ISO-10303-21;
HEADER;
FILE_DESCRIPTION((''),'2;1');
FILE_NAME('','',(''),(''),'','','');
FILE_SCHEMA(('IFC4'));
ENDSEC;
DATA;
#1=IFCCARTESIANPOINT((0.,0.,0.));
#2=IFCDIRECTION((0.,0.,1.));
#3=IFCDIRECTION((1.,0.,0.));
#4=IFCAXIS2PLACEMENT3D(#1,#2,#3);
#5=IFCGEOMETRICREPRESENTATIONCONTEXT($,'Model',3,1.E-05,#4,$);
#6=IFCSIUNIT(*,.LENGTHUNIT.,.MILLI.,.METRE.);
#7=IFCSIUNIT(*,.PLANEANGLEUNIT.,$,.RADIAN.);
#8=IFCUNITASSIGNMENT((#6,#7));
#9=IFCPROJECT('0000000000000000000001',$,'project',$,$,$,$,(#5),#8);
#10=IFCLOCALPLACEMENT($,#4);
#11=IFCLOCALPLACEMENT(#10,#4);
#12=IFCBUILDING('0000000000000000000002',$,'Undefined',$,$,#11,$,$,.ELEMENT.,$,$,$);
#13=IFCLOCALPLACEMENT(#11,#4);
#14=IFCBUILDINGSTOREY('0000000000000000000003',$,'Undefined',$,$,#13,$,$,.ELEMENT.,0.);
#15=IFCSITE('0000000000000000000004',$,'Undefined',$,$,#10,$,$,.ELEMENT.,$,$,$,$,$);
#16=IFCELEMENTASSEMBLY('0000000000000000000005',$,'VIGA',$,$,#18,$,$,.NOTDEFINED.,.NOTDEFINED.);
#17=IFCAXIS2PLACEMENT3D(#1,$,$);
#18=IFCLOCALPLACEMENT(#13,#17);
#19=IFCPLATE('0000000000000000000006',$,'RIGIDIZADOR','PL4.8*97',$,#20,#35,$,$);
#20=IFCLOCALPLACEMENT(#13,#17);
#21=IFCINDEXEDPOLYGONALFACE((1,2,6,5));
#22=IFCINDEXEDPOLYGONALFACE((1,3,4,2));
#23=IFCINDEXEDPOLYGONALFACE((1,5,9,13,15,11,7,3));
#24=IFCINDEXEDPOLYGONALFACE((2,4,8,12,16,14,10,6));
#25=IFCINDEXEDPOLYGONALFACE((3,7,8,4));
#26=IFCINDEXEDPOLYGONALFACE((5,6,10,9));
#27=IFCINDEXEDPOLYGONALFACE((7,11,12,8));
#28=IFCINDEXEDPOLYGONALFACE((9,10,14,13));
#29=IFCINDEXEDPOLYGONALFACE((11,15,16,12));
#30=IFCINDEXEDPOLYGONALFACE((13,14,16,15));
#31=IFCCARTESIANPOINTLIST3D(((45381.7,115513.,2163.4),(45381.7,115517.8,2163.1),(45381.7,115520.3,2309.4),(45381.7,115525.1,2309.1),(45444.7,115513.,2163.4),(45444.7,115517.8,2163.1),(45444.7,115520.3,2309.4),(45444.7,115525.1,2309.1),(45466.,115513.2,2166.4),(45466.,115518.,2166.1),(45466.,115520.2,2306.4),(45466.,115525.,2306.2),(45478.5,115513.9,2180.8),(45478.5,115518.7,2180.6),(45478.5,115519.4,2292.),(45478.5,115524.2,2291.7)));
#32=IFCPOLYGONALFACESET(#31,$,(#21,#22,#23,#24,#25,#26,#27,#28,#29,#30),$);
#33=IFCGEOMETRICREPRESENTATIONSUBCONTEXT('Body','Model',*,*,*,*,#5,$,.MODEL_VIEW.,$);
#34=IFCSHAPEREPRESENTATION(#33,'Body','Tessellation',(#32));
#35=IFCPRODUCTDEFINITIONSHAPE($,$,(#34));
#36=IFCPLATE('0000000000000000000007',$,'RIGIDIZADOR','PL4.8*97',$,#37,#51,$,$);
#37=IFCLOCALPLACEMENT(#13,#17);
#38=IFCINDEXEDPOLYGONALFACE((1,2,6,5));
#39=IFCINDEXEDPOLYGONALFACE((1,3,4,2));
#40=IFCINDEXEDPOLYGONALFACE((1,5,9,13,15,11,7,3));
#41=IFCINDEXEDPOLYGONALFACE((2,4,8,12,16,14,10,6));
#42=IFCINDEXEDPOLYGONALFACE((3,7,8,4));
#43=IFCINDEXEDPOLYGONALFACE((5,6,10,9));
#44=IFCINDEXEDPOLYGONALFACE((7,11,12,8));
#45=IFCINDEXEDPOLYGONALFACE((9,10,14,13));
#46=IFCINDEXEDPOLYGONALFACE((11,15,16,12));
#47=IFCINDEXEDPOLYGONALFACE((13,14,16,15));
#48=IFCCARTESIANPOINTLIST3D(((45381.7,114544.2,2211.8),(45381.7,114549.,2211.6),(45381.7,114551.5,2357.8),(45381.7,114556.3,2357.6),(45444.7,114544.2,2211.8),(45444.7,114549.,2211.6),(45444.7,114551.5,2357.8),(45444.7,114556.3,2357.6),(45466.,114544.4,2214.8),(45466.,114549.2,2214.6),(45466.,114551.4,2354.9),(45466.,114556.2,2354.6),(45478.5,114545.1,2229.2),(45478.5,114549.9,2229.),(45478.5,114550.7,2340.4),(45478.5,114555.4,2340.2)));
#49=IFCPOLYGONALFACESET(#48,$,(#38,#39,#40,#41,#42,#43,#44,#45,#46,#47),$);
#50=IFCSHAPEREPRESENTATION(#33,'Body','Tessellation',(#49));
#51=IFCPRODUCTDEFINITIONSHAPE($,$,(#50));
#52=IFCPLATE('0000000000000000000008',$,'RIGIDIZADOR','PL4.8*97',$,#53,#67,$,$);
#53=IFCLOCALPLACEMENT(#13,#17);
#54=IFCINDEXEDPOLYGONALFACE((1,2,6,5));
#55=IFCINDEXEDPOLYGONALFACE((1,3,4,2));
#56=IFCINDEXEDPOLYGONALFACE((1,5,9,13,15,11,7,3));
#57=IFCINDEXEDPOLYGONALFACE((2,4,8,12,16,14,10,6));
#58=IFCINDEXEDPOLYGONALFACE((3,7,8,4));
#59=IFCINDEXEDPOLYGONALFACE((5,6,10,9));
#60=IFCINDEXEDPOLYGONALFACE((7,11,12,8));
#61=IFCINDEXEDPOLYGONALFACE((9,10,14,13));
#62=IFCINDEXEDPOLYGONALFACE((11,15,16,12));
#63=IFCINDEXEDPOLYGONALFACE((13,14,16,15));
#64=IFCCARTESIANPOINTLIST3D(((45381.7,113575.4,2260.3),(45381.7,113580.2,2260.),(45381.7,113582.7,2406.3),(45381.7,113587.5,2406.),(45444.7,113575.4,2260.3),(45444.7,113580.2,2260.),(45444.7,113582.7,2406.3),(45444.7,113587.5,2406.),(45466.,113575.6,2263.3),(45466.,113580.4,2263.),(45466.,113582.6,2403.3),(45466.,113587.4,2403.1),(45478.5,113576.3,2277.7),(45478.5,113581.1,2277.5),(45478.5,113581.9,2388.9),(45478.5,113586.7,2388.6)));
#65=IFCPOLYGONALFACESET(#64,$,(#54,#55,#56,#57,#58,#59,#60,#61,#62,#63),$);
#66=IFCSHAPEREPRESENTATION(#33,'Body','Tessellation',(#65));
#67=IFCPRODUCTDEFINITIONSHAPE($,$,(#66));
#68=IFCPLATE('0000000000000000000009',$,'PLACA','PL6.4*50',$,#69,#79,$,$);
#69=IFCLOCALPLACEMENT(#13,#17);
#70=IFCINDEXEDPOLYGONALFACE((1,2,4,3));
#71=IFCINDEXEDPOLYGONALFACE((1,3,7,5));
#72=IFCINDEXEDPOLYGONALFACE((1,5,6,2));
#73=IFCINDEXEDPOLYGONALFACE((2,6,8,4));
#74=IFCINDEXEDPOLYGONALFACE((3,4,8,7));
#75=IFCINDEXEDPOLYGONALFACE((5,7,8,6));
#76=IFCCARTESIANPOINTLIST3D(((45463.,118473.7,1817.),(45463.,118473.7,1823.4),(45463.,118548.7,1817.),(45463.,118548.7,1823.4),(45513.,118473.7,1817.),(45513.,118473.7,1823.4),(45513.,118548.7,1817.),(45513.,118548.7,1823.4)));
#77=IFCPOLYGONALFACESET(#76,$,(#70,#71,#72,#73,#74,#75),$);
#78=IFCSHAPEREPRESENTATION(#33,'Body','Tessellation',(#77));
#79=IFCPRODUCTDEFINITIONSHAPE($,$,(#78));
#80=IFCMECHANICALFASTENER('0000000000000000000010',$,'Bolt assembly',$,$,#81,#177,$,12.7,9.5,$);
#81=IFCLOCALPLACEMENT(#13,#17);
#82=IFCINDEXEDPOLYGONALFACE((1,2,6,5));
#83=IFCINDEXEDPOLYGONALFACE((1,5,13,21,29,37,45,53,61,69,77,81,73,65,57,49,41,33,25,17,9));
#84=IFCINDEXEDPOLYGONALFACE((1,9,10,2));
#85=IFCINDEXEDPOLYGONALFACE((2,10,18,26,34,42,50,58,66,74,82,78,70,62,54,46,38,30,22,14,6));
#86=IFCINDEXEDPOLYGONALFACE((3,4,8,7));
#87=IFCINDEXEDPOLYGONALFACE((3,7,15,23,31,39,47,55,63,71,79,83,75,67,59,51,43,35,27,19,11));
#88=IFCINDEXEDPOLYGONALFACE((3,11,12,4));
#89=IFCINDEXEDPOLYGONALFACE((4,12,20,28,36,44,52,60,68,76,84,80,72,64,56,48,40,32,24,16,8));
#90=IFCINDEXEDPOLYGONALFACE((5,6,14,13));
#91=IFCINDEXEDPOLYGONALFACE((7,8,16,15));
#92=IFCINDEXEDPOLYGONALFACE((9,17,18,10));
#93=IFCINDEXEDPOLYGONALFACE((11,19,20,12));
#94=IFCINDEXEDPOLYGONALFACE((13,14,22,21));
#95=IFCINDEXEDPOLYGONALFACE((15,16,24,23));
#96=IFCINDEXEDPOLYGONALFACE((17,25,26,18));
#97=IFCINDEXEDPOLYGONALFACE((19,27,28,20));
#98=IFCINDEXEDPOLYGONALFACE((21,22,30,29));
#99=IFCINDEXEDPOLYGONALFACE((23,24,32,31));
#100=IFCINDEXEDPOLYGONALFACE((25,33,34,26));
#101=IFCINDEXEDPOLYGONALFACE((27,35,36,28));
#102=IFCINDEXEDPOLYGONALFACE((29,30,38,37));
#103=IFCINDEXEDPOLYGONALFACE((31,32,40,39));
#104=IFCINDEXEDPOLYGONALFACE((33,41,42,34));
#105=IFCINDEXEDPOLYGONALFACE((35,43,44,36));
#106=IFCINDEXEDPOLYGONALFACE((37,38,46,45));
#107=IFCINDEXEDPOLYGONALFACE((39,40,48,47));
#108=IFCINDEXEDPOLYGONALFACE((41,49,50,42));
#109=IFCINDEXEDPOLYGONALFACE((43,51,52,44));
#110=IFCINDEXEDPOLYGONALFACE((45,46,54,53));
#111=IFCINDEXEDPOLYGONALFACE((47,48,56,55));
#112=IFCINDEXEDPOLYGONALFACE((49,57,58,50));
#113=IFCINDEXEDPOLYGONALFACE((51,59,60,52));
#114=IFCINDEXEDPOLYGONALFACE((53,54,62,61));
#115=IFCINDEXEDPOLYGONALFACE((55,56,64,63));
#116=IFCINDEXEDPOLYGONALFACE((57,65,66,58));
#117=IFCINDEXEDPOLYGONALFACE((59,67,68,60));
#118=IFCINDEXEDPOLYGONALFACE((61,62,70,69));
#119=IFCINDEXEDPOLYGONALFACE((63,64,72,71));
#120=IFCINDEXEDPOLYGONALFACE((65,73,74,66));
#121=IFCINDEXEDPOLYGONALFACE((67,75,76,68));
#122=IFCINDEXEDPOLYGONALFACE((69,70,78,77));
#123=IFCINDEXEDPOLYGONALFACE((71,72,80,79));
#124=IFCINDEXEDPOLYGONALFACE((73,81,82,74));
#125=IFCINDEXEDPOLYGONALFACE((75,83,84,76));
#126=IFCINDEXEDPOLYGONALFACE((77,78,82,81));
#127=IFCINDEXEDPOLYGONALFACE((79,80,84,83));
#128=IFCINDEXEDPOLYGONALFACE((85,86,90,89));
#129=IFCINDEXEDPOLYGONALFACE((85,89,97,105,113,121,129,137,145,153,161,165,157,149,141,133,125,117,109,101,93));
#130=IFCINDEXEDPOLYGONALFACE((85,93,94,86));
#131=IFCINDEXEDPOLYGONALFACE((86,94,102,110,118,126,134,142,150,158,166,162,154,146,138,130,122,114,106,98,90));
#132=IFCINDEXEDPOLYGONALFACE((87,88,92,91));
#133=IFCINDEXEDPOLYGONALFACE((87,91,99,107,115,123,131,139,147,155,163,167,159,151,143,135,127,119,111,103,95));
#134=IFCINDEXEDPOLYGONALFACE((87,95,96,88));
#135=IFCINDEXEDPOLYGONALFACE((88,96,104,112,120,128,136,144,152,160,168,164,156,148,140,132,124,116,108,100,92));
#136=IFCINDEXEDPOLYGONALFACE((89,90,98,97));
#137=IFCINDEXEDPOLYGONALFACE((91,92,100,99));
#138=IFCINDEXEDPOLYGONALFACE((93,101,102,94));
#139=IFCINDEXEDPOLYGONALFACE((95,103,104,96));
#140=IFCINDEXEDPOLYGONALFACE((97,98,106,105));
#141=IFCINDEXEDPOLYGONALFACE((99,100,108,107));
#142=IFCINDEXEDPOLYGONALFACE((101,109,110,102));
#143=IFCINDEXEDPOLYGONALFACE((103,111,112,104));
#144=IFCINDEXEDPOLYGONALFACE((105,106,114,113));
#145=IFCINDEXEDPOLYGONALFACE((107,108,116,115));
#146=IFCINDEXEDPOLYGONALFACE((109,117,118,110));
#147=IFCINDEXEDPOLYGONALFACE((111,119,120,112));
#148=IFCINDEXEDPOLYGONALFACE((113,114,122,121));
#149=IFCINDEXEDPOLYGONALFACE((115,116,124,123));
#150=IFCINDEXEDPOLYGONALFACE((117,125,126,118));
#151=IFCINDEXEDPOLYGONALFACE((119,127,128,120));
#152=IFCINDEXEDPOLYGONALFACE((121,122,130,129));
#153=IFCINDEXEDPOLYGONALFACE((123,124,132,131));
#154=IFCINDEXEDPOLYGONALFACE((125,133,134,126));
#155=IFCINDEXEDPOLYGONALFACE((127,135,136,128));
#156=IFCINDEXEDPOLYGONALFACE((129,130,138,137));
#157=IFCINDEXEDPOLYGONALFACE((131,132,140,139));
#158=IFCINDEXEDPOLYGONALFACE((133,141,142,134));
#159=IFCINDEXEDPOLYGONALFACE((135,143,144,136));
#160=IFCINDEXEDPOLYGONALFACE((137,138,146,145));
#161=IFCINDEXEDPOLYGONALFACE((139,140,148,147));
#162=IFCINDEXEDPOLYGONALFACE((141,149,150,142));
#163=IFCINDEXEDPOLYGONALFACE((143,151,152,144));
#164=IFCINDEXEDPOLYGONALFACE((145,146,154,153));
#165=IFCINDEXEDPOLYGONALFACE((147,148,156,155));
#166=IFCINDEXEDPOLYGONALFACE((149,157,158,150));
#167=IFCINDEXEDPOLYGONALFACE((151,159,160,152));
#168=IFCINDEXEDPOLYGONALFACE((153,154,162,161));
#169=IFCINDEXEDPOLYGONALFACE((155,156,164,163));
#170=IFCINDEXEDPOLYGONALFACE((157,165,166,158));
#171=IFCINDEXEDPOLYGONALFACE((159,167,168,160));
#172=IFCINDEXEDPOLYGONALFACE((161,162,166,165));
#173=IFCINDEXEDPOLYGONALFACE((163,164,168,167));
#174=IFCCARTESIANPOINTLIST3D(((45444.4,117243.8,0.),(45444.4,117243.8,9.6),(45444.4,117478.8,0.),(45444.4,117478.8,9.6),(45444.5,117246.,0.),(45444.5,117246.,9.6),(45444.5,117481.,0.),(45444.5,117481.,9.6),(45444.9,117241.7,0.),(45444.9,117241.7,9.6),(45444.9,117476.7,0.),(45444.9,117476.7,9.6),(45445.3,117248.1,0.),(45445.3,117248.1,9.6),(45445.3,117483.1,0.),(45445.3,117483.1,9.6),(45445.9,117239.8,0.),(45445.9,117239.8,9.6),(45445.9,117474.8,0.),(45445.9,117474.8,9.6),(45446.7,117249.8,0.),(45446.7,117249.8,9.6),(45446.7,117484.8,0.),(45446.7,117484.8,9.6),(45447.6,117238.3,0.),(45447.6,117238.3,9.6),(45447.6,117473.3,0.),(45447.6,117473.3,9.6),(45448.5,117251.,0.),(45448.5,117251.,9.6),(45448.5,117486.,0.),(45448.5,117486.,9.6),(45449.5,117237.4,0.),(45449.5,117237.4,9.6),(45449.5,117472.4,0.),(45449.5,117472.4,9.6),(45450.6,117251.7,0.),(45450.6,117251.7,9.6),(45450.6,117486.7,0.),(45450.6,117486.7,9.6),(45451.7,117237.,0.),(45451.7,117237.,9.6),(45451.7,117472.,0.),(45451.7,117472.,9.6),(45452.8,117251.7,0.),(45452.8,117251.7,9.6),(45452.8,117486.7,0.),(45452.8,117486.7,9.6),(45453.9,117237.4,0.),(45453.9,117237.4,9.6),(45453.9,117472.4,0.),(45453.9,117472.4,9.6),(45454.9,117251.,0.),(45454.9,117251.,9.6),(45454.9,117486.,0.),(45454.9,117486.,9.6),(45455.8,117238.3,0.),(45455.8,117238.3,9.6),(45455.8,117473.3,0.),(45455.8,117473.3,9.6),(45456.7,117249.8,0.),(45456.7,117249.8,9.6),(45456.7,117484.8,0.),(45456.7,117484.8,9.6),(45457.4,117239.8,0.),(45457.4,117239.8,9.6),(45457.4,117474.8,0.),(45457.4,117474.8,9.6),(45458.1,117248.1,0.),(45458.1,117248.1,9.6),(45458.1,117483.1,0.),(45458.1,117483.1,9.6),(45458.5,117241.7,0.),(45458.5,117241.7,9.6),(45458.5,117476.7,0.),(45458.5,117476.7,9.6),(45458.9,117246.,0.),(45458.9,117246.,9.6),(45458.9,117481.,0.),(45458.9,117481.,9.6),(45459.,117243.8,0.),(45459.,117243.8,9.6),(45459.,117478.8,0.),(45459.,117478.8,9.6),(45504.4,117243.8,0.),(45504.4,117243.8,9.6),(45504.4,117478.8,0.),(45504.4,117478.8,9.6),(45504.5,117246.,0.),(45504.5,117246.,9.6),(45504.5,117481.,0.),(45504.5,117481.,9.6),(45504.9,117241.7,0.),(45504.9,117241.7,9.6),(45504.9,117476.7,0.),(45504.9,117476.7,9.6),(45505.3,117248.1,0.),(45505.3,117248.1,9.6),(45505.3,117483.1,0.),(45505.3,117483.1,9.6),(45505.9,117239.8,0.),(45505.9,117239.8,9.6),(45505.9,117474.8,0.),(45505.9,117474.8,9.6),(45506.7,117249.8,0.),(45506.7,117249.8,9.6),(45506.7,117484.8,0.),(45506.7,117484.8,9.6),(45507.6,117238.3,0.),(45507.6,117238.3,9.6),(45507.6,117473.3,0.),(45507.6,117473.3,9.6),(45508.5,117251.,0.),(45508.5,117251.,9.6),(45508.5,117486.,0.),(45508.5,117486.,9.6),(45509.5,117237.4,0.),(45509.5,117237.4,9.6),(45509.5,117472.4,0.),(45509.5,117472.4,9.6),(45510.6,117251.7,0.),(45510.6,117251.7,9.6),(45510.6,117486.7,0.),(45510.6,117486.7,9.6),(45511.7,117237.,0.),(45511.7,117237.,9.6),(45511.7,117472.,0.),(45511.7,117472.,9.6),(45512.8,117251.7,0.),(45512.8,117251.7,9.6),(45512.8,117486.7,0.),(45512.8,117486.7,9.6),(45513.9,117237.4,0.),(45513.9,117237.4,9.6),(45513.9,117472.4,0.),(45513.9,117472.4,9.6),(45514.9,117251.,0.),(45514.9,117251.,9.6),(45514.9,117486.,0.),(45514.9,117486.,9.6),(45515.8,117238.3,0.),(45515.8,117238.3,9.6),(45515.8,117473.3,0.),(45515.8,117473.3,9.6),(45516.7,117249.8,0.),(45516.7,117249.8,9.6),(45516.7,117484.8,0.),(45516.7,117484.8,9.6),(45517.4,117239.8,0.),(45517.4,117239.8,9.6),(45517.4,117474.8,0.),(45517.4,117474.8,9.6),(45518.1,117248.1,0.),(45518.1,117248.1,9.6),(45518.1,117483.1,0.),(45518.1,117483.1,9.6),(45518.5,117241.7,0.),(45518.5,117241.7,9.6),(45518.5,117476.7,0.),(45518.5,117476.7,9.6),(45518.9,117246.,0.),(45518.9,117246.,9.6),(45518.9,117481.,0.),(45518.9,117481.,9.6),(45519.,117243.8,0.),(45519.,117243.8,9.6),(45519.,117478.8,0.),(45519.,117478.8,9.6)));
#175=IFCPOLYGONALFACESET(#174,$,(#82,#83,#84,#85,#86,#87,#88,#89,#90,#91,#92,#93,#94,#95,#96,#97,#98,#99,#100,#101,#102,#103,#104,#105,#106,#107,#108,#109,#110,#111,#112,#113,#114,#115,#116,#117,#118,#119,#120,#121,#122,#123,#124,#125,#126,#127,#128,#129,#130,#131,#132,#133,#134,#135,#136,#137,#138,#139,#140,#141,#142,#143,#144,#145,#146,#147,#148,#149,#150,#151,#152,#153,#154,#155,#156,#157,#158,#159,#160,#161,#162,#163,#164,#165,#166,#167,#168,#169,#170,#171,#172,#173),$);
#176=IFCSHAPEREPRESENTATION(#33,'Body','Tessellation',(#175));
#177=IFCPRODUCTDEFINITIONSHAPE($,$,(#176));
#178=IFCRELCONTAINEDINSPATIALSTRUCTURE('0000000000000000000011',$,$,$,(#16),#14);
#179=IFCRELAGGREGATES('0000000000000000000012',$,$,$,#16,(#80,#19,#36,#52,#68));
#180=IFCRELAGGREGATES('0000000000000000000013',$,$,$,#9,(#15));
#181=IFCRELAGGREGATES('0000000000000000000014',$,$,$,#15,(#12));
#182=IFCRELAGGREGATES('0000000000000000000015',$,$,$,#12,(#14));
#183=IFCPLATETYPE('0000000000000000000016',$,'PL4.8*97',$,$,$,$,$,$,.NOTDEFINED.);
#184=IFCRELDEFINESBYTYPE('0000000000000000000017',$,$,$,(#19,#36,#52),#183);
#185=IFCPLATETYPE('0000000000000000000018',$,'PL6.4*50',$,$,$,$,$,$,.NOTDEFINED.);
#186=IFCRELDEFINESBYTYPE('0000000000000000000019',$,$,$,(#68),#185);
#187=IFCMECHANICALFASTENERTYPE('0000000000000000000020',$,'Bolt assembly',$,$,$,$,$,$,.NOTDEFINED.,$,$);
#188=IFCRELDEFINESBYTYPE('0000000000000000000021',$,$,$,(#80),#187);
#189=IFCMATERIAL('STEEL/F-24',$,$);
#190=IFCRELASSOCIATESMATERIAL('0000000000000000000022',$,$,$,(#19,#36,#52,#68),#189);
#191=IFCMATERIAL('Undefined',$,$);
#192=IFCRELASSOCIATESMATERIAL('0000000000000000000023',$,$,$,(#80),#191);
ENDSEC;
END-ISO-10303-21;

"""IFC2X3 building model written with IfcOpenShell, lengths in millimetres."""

from ifc_helpers import new_model, si_unit, frame, origin_with_axes, origin_2d_with_axis, place, context, subcontext, project, spatial, polyline, circle, outline, extrude, source, transform, mapped, material, type_object, element, aggregate, save


model = new_model("IFC2X3")

# Units and contexts
model_context = context("Model", 3, precision=1e-05, world=origin_with_axes())
body_context = subcontext(model_context, "Body", "Model", "MODEL_VIEW")
ifc_project = project(units=[si_unit("LENGTHUNIT", "METRE", prefix="MILLI"), si_unit("PLANEANGLEUNIT", "RADIAN")], contexts=[model_context])

# Site, building, storey
site_placement = place(None, origin_with_axes())
site = spatial("IfcSite", under=ifc_project, at=site_placement, Name="Undefined", CompositionType="ELEMENT")
building_placement = place(site_placement, origin_with_axes())
building = spatial("IfcBuilding", under=site, at=building_placement, Name="Undefined", CompositionType="ELEMENT")
storey_placement = place(building_placement, origin_with_axes())
storey = spatial("IfcBuildingStorey", under=building, at=storey_placement, Name="Undefined", CompositionType="ELEMENT", Elevation=0.0)

# Element assembly
assembly_1_placement = place(storey_placement, origin_with_axes())
assembly_1 = element("IfcElementAssembly", 1, at=assembly_1_placement, inside=storey, Name="VIGA", AssemblyPlace="NOTDEFINED", PredefinedType="NOTDEFINED")
ifc_material_1 = material(Name="STEEL/F-24")

# Plates
plate_type_1 = type_object("IfcPlateType", Name="PL4.8*97", PredefinedType="NOTDEFINED")
plate_1_placement = place(assembly_1_placement, frame((45381.7, 115522.7, 2309.3), z_axis=(0.0, 0.998752, -0.04995), x_axis=(1.0, 0.0, 0.0)))
plate_1 = element("IfcPlate", 2, at=plate_1_placement, type_object=plate_type_1, material=ifc_material_1, Name="RIGIDIZADOR", Description="PL4.8*97", context=body_context, shape_type="SweptSolid", body=[
    extrude(outline(polyline([(0.0, 0.0), (63.0, 0.0), (84.3, 3.0), (96.8, 17.4), (96.8, 128.7), (84.3, 143.2), (63.0, 146.2), (0.0, 146.2), (0.0, 0.0)])), frame((0.0, 0.0, -2.4), z_axis=(0.0, 0.0, 1.0), x_axis=(1.0, 0.0, 0.0)), (0.0, 0.0, 1.0), 4.8),
])
plate_2_placement = place(assembly_1_placement, frame((45381.7, 114553.9, 2357.7), z_axis=(0.0, 0.998752, -0.04995), x_axis=(1.0, 0.0, 0.0)))
plate_2 = element("IfcPlate", 3, at=plate_2_placement, type_object=plate_type_1, material=ifc_material_1, Name="RIGIDIZADOR", Description="PL4.8*97", context=body_context, shape_type="SweptSolid", body=[
    extrude(outline(polyline([(0.0, 0.0), (63.0, 0.0), (84.3, 3.0), (96.8, 17.4), (96.8, 128.7), (84.3, 143.2), (63.0, 146.2), (0.0, 146.2), (0.0, 0.0)])), frame((0.0, 0.0, -2.4), z_axis=(0.0, 0.0, 1.0), x_axis=(1.0, 0.0, 0.0)), (0.0, 0.0, 1.0), 4.8),
])
plate_3_placement = place(assembly_1_placement, frame((45381.7, 113585.1, 2406.2), z_axis=(0.0, 0.998752, -0.04995), x_axis=(1.0, 0.0, 0.0)))
plate_3 = element("IfcPlate", 4, at=plate_3_placement, type_object=plate_type_1, material=ifc_material_1, Name="RIGIDIZADOR", Description="PL4.8*97", context=body_context, shape_type="SweptSolid", body=[
    extrude(outline(polyline([(0.0, 0.0), (63.0, 0.0), (84.3, 3.0), (96.8, 17.4), (96.8, 128.7), (84.3, 143.2), (63.0, 146.2), (0.0, 146.2), (0.0, 0.0)])), frame((0.0, 0.0, -2.4), z_axis=(0.0, 0.0, 1.0), x_axis=(1.0, 0.0, 0.0)), (0.0, 0.0, 1.0), 4.8),
])
plate_type_2 = type_object("IfcPlateType", Name="PL6.4*50", PredefinedType="NOTDEFINED")
plate_4_placement = place(assembly_1_placement, frame((45463.0, 118473.7, 1820.2), z_axis=(0.0, 0.0, -1.0), x_axis=(0.0, 1.0, 0.0)))
plate_4 = element("IfcPlate", 5, at=plate_4_placement, type_object=plate_type_2, material=ifc_material_1, Name="PLACA", Description="PL6.4*50", context=body_context, shape_type="SweptSolid", body=[
    extrude(outline(polyline([(0.0, 0.0), (75.0, 0.0), (75.0, 50.0), (0.0, 50.0), (0.0, 0.0)])), frame((0.0, 0.0, -3.2), z_axis=(0.0, 0.0, 1.0), x_axis=(1.0, 0.0, 0.0)), (0.0, 0.0, 1.0), 6.4),
])

# Shared definitions
ifc_material_2 = material(Name="Undefined")
mechanical_fastener_type = type_object("IfcMechanicalFastenerType", Name="Bolt assembly")

# Mechanical fastener
shared_shape_1 = source(origin_with_axes(), body_context, "Body", "SweptSolid", [
    extrude(circle(Radius=7.3, at=origin_2d_with_axis()), frame((0.0, -9.5, 0.0), z_axis=(0.0, 1.0, 0.0), x_axis=(1.0, 0.0, 0.0)), (0.0, 0.0, 1.0), 9.6),
])
mechanical_fastener_1_placement = place(assembly_1_placement, frame((45481.7, 117479.4, 9.5), z_axis=(-1.0, 0.0, 0.0), x_axis=(0.0, -1.0, 0.0)))
mechanical_fastener_1 = element("IfcMechanicalFastener", 6, at=mechanical_fastener_1_placement, type_object=mechanical_fastener_type, material=ifc_material_2, Name="Bolt assembly", NominalDiameter=12.7, NominalLength=9.5, context=body_context, shape_type="MappedRepresentation", body=[
    mapped(shared_shape_1, transform((0.0, 0.0, 30.0))),
    mapped(shared_shape_1, transform((235.0, 0.0, 30.0))),
    mapped(shared_shape_1, transform((0.0, 0.0, -30.0))),
    mapped(shared_shape_1, transform((235.0, 0.0, -30.0))),
])
aggregate(assembly_1, [mechanical_fastener_1, plate_1, plate_2, plate_3, plate_4])

save(model, "model.ifc")
